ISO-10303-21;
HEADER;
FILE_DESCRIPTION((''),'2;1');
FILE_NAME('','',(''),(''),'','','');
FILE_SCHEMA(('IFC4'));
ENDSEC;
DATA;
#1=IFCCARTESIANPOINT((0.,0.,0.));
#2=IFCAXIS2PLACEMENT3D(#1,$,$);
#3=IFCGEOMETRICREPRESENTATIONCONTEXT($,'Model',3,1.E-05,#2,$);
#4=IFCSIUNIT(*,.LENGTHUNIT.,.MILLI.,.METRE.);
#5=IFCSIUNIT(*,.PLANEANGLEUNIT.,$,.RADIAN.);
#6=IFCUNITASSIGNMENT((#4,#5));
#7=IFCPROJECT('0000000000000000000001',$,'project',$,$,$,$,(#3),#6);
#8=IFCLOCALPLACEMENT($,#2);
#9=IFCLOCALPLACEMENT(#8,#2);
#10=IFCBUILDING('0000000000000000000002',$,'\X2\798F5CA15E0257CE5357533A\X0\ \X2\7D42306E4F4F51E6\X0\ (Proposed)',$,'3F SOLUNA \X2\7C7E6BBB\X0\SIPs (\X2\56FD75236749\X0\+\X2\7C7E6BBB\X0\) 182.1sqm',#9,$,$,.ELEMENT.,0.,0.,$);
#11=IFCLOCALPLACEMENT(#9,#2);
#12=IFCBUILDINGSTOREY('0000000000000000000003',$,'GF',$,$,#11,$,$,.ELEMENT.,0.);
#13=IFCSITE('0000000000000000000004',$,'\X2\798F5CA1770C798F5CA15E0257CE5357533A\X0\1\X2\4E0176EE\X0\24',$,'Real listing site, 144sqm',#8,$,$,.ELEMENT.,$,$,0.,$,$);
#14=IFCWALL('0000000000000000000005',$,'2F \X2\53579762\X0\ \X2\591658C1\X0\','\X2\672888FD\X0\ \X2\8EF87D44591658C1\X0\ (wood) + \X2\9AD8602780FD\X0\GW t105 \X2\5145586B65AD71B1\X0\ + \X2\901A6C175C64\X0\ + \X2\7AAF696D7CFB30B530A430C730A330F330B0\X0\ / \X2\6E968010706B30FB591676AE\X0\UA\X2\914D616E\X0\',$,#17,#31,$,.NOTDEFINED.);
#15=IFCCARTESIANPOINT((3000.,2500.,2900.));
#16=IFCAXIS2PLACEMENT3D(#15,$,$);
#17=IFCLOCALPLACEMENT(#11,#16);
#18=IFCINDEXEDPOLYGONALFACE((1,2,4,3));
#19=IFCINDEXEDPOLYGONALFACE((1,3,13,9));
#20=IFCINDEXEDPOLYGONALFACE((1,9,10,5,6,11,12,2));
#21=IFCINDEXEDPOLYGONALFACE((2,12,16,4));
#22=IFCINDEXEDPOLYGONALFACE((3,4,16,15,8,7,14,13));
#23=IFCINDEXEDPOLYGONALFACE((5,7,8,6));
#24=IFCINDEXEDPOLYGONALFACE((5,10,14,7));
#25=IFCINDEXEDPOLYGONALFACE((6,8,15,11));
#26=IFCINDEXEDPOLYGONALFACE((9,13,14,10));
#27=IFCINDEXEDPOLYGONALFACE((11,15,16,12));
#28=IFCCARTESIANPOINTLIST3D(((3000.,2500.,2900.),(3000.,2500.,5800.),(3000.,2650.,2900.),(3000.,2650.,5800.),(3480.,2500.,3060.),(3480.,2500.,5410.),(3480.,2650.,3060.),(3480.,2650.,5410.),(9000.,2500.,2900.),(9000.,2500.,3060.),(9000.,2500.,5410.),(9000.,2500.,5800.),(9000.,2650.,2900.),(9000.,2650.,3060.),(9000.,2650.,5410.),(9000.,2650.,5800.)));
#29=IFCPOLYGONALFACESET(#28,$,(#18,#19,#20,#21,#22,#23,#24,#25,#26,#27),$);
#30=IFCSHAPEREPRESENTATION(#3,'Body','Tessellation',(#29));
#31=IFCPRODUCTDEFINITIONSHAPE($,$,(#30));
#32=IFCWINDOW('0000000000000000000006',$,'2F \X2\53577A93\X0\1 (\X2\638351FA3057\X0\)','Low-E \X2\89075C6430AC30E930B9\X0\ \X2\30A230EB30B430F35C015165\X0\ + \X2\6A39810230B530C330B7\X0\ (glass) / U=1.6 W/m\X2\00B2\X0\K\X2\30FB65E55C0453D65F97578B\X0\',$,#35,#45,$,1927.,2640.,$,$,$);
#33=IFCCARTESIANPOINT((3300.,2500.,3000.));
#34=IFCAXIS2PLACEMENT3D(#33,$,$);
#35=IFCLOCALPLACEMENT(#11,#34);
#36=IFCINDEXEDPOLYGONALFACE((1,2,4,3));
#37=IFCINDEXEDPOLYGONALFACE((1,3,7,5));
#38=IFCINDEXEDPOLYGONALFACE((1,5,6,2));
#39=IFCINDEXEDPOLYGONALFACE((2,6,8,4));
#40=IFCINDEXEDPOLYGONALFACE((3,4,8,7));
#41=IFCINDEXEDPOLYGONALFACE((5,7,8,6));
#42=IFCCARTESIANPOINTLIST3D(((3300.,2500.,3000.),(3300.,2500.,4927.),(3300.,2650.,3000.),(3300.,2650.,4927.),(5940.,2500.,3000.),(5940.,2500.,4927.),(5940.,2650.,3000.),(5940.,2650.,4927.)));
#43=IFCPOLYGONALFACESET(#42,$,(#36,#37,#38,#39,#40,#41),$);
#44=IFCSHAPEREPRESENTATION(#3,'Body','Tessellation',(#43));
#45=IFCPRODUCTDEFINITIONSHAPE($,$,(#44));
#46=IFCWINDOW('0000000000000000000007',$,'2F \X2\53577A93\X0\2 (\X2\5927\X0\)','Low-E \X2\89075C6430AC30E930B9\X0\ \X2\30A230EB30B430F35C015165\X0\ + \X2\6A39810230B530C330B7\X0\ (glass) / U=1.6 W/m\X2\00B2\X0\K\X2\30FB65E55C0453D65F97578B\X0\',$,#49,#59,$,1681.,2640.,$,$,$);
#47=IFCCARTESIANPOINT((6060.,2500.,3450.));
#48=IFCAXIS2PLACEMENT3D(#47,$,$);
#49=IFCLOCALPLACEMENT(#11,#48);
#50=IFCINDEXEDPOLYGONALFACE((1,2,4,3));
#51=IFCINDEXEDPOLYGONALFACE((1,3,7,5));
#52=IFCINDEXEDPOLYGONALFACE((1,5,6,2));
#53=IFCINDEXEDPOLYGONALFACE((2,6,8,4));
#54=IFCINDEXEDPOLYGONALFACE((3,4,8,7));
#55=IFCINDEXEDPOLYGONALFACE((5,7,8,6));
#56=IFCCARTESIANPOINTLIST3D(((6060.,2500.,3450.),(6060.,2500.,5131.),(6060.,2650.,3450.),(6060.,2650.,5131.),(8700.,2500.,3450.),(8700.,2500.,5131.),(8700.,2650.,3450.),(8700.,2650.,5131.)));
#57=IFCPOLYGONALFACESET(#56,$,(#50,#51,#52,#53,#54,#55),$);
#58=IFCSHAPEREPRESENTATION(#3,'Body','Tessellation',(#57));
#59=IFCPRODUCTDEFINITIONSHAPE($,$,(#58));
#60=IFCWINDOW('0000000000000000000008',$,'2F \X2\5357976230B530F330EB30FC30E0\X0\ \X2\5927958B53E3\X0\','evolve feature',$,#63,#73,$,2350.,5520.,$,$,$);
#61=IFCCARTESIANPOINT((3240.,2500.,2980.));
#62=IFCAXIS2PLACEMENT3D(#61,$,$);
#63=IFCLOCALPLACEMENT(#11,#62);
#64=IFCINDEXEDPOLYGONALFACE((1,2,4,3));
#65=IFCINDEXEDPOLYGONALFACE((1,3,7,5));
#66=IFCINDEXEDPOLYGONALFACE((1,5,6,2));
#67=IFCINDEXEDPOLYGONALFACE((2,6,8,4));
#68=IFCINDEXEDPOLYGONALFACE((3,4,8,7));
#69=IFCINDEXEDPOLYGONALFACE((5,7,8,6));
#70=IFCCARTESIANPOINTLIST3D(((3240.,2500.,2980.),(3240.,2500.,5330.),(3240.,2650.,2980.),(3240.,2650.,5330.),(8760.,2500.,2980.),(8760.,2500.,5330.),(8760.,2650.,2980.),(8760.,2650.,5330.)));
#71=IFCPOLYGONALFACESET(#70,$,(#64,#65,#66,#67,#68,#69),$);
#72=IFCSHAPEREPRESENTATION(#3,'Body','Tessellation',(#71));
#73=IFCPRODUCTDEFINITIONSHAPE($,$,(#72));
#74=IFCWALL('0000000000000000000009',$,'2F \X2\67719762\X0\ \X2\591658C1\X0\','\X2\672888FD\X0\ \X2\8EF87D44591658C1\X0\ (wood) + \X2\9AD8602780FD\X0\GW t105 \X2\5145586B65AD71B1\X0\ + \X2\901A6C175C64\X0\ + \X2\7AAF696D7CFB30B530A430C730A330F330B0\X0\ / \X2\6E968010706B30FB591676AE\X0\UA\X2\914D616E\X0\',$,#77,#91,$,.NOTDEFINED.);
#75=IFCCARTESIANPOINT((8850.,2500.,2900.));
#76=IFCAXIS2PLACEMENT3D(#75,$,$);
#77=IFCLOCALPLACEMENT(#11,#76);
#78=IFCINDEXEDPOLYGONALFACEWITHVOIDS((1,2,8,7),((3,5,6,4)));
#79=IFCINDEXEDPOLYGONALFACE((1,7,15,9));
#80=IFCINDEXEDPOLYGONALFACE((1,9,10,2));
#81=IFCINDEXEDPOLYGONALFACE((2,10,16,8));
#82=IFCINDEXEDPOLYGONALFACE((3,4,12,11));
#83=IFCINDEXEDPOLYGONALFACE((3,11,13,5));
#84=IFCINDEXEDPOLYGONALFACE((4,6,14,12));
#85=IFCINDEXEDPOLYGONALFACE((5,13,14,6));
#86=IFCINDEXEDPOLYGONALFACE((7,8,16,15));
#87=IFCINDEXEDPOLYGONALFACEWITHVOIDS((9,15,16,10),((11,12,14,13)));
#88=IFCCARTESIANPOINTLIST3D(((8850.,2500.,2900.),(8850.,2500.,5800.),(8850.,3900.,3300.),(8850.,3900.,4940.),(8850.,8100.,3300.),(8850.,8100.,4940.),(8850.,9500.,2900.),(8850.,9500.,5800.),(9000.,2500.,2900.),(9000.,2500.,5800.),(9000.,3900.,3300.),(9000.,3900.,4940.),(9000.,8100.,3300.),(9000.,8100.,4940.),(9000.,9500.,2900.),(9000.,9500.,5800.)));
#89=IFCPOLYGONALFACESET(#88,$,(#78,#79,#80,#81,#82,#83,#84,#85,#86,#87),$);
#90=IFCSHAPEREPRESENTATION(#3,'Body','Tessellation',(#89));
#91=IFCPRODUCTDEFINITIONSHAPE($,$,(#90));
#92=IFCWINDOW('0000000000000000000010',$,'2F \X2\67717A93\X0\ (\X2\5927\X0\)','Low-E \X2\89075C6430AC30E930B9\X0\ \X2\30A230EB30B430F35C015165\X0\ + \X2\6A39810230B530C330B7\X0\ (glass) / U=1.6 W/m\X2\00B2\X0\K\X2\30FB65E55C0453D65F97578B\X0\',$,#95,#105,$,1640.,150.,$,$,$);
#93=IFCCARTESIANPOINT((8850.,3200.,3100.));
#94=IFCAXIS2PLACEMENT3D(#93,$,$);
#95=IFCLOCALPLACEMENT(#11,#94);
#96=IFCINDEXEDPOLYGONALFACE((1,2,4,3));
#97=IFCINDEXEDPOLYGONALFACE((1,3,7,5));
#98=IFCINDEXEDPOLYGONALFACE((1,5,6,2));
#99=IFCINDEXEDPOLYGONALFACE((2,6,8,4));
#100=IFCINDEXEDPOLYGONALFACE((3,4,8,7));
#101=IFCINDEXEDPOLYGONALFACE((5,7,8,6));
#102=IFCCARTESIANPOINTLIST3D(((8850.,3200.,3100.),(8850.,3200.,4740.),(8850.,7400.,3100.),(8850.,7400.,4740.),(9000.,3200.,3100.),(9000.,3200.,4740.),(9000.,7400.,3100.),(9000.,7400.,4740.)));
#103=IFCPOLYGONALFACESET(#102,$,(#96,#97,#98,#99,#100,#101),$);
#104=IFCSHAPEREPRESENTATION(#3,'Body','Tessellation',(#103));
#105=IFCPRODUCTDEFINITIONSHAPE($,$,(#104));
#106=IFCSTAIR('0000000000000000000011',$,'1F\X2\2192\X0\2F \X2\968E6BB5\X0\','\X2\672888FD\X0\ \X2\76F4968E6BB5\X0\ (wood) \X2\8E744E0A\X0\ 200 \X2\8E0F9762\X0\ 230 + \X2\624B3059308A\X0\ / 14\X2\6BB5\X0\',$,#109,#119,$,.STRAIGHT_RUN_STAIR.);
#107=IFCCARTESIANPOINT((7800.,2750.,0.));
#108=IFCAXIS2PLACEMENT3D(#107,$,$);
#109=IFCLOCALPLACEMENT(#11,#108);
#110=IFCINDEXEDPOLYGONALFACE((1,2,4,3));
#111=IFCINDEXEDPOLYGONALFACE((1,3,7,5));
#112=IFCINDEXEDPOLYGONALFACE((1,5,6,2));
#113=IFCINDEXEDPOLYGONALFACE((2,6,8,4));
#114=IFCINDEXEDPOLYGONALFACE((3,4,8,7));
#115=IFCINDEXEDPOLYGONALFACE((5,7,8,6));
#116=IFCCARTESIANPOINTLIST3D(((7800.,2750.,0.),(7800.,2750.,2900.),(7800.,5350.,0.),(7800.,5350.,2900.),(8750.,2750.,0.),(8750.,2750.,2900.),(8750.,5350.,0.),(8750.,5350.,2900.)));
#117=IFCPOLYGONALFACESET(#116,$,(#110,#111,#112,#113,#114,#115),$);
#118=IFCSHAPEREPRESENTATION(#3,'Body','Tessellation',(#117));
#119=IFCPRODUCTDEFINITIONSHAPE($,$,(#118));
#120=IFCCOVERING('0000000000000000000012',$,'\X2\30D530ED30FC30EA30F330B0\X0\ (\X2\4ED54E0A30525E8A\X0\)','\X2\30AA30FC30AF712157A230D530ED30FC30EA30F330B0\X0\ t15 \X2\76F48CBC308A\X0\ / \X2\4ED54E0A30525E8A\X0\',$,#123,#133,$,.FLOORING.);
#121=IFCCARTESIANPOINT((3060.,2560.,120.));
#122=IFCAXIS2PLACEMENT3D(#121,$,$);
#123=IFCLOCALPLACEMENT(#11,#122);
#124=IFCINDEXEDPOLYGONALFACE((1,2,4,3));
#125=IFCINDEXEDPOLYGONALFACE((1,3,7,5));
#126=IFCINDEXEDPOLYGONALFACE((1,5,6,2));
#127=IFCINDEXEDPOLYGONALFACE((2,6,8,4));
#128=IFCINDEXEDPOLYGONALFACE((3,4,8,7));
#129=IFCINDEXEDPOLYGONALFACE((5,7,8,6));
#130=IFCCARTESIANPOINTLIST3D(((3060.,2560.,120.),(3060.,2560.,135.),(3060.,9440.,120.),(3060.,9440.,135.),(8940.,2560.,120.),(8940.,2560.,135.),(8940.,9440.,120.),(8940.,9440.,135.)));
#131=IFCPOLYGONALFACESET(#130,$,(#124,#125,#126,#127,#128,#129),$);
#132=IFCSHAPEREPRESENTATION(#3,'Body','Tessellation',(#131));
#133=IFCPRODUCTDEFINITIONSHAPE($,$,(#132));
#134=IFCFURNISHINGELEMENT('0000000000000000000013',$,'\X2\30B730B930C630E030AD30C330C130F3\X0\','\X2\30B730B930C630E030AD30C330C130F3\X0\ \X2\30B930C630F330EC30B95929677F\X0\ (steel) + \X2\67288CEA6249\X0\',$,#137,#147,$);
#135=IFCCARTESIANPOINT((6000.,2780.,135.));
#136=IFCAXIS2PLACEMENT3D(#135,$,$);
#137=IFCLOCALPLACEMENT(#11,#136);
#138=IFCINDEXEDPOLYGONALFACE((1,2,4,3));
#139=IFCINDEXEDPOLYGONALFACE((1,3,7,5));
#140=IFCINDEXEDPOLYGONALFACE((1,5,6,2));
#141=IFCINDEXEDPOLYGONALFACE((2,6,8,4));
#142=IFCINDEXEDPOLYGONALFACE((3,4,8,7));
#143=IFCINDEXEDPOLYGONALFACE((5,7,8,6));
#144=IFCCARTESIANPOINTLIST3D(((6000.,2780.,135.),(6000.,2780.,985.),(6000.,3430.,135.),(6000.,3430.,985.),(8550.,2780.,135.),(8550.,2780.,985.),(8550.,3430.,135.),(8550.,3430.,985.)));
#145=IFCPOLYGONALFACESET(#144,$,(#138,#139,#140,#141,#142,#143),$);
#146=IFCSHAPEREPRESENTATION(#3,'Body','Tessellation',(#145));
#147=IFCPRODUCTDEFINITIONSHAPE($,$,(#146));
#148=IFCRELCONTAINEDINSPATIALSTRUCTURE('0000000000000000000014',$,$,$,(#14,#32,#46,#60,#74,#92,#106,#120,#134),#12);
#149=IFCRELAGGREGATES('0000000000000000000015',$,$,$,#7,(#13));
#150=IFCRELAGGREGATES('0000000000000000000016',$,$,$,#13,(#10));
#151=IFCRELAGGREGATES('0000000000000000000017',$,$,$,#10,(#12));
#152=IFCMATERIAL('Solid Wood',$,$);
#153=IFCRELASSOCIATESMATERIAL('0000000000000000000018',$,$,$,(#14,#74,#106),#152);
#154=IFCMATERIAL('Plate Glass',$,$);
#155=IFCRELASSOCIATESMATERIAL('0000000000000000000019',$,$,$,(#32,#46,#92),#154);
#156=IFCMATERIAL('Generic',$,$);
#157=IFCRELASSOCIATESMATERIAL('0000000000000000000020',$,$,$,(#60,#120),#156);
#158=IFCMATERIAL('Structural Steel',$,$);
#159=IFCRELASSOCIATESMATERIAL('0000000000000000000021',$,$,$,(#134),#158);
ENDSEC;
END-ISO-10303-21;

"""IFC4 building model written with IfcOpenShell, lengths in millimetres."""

from ifc_helpers import new_model, si_unit, frame, frame_2d, origin, place, context, project, spatial, rectangle, extrude, material, element, fill, save


model = new_model("IFC4")

# Units and contexts
model_context = context("Model", 3, precision=1e-05, world=origin())
ifc_project = project(units=[si_unit("LENGTHUNIT", "METRE", prefix="MILLI"), si_unit("PLANEANGLEUNIT", "RADIAN")], contexts=[model_context])

# Site, building, storey
site_placement = place(None, origin())
site = spatial("IfcSite", under=ifc_project, at=site_placement, Name="福岡県福岡市城南区1丁目24", ObjectType="Real listing site, 144sqm", CompositionType="ELEMENT", RefElevation=0.0)
building_placement = place(site_placement, origin())
building = spatial("IfcBuilding", under=site, at=building_placement, Name="福岡市城南区 終の住処 (Proposed)", ObjectType="3F SOLUNA 籾殻SIPs (国産杉+籾殻) 182.1sqm", CompositionType="ELEMENT", ElevationOfRefHeight=0.0, ElevationOfTerrain=0.0)
storey_placement = place(building_placement, origin())
storey = spatial("IfcBuildingStorey", under=building, at=storey_placement, Name="GF", CompositionType="ELEMENT", Elevation=0.0)

# Shared definitions
ifc_material_1 = material(Name="Solid Wood")

# Shared definitions
ifc_material_2 = material(Name="Plate Glass")
ifc_material_3 = material(Name="Generic")

# Wall, openings, windows
wall_1_placement = place(storey_placement, frame((3000.0, 2500.0, 2900.0)))
wall_1 = element("IfcWall", 1, at=wall_1_placement, inside=storey, material=ifc_material_1, Name="2F 南面 外壁", Description="木製 軸組外壁 (wood) + 高性能GW t105 充填断熱 + 通気層 + 窯業系サイディング / 準耐火・外皮UA配慮", PredefinedType="NOTDEFINED", context=model_context, shape_type="SweptSolid", body=[
    extrude(rectangle(XDim=6000.0, YDim=150.0, at=frame_2d((3000.0, 75.0))), frame((3000.0, 2500.0, 2900.0)), (0.0, 0.0, 1.0), 2900.0),
])
opening_1_placement = place(storey_placement, frame((3300.0, 2500.0, 3000.0)))
opening_1 = element("IfcOpeningElement", 2, at=opening_1_placement, cuts=wall_1, PredefinedType="NOTDEFINED", context=model_context, shape_type="SweptSolid", body=[
    extrude(rectangle(XDim=2640.0, YDim=150.0, at=frame_2d((1320.0, 75.0))), frame((3300.0, 2500.0, 3000.0)), (0.0, 0.0, 1.0), 1927.0),
])
opening_2_placement = place(storey_placement, frame((6060.0, 2500.0, 3450.0)))
opening_2 = element("IfcOpeningElement", 3, at=opening_2_placement, cuts=wall_1, PredefinedType="NOTDEFINED", context=model_context, shape_type="SweptSolid", body=[
    extrude(rectangle(XDim=2640.0, YDim=150.0, at=frame_2d((1320.0, 75.0))), frame((6060.0, 2500.0, 3450.0)), (0.0, 0.0, 1.0), 1681.0),
])
opening_3_placement = place(storey_placement, frame((3240.0, 2500.0, 2980.0)))
opening_3 = element("IfcOpeningElement", 4, at=opening_3_placement, cuts=wall_1, PredefinedType="NOTDEFINED", context=model_context, shape_type="SweptSolid", body=[
    extrude(rectangle(XDim=5520.0, YDim=150.0, at=frame_2d((2760.0, 75.0))), frame((3240.0, 2500.0, 2980.0)), (0.0, 0.0, 1.0), 2350.0),
])
window_1_placement = place(storey_placement, frame((3300.0, 2500.0, 3000.0)))
window_1 = element("IfcWindow", 5, at=window_1_placement, inside=storey, material=ifc_material_2, Name="2F 南窓1 (掃出し)", Description="Low-E 複層ガラス アルゴン封入 + 樹脂サッシ (glass) / U=1.6 W/m²K・日射取得型", OverallHeight=1927.0, OverallWidth=2640.0, context=model_context, shape_type="SweptSolid", body=[
    extrude(rectangle(XDim=2640.0, YDim=150.0, at=frame_2d((1320.0, 75.0))), frame((3300.0, 2500.0, 3000.0)), (0.0, 0.0, 1.0), 1927.0),
])
fill(opening_1, window_1)
window_2_placement = place(storey_placement, frame((6060.0, 2500.0, 3450.0)))
window_2 = element("IfcWindow", 6, at=window_2_placement, inside=storey, material=ifc_material_2, Name="2F 南窓2 (大)", Description="Low-E 複層ガラス アルゴン封入 + 樹脂サッシ (glass) / U=1.6 W/m²K・日射取得型", OverallHeight=1681.0, OverallWidth=2640.0, context=model_context, shape_type="SweptSolid", body=[
    extrude(rectangle(XDim=2640.0, YDim=150.0, at=frame_2d((1320.0, 75.0))), frame((6060.0, 2500.0, 3450.0)), (0.0, 0.0, 1.0), 1681.0),
])
fill(opening_2, window_2)
window_3_placement = place(storey_placement, frame((3240.0, 2500.0, 2980.0)))
window_3 = element("IfcWindow", 7, at=window_3_placement, inside=storey, material=ifc_material_3, Name="2F 南面サンルーム 大開口", Description="evolve feature", OverallHeight=2350.0, OverallWidth=5520.0, context=model_context, shape_type="SweptSolid", body=[
    extrude(rectangle(XDim=5520.0, YDim=150.0, at=frame_2d((2760.0, 75.0))), frame((3240.0, 2500.0, 2980.0)), (0.0, 0.0, 1.0), 2350.0),
])
fill(opening_3, window_3)

# Wall, opening, window
wall_2_placement = place(storey_placement, frame((8850.0, 2500.0, 2900.0)))
wall_2 = element("IfcWall", 8, at=wall_2_placement, inside=storey, material=ifc_material_1, Name="2F 東面 外壁", Description="木製 軸組外壁 (wood) + 高性能GW t105 充填断熱 + 通気層 + 窯業系サイディング / 準耐火・外皮UA配慮", PredefinedType="NOTDEFINED", context=model_context, shape_type="SweptSolid", body=[
    extrude(rectangle(XDim=150.0, YDim=7000.0, at=frame_2d((75.0, 3500.0))), frame((8850.0, 2500.0, 2900.0)), (0.0, 0.0, 1.0), 2900.0),
])
opening_4_placement = place(storey_placement, frame((8850.0, 3200.0, 3100.0)))
opening_4 = element("IfcOpeningElement", 9, at=opening_4_placement, cuts=wall_2, PredefinedType="NOTDEFINED", context=model_context, shape_type="SweptSolid", body=[
    extrude(rectangle(XDim=150.0, YDim=4200.0, at=frame_2d((75.0, 2100.0))), frame((8850.0, 3200.0, 3100.0)), (0.0, 0.0, 1.0), 1640.0),
])
window_4_placement = place(storey_placement, frame((8850.0, 3200.0, 3100.0)))
window_4 = element("IfcWindow", 10, at=window_4_placement, inside=storey, material=ifc_material_2, Name="2F 東窓 (大)", Description="Low-E 複層ガラス アルゴン封入 + 樹脂サッシ (glass) / U=1.6 W/m²K・日射取得型", OverallHeight=1640.0, OverallWidth=150.0, context=model_context, shape_type="SweptSolid", body=[
    extrude(rectangle(XDim=150.0, YDim=4200.0, at=frame_2d((75.0, 2100.0))), frame((8850.0, 3200.0, 3100.0)), (0.0, 0.0, 1.0), 1640.0),
])
fill(opening_4, window_4)

# Stair
stair_placement = place(storey_placement, frame((7800.0, 2750.0, 0.0)))
element("IfcStair", 11, at=stair_placement, inside=storey, material=ifc_material_1, Name="1F→2F 階段", Description="木製 直階段 (wood) 蹴上 200 踏面 230 + 手すり / 14段", PredefinedType="STRAIGHT_RUN_STAIR", context=model_context, shape_type="SweptSolid", body=[
    extrude(rectangle(XDim=950.0, YDim=2600.0, at=frame_2d((475.0, 1300.0))), frame((7800.0, 2750.0, 0.0)), (0.0, 0.0, 1.0), 2900.0),
])

# Covering
covering_placement = place(storey_placement, frame((3060.0, 2560.0, 120.0)))
element("IfcCovering", 12, at=covering_placement, inside=storey, material=ifc_material_3, Name="フローリング (仕上げ床)", Description="オーク無垢フローリング t15 直貼り / 仕上げ床", PredefinedType="FLOORING", context=model_context, shape_type="SweptSolid", body=[
    extrude(rectangle(XDim=5880.0, YDim=6880.0, at=frame_2d((2940.0, 3440.0))), frame((3060.0, 2560.0, 120.0)), (0.0, 0.0, 1.0), 15.0),
])

# Furnishing element
ifc_material_4 = material(Name="Structural Steel")
furnishing_placement = place(storey_placement, frame((6000.0, 2780.0, 135.0)))
element("IfcFurnishingElement", 13, at=furnishing_placement, inside=storey, material=ifc_material_4, Name="システムキッチン", Description="システムキッチン ステンレス天板 (steel) + 木質扉", context=model_context, shape_type="SweptSolid", body=[
    extrude(rectangle(XDim=2550.0, YDim=650.0, at=frame_2d((1275.0, 325.0))), frame((6000.0, 2780.0, 135.0)), (0.0, 0.0, 1.0), 850.0),
])

save(model, "model.ifc")
